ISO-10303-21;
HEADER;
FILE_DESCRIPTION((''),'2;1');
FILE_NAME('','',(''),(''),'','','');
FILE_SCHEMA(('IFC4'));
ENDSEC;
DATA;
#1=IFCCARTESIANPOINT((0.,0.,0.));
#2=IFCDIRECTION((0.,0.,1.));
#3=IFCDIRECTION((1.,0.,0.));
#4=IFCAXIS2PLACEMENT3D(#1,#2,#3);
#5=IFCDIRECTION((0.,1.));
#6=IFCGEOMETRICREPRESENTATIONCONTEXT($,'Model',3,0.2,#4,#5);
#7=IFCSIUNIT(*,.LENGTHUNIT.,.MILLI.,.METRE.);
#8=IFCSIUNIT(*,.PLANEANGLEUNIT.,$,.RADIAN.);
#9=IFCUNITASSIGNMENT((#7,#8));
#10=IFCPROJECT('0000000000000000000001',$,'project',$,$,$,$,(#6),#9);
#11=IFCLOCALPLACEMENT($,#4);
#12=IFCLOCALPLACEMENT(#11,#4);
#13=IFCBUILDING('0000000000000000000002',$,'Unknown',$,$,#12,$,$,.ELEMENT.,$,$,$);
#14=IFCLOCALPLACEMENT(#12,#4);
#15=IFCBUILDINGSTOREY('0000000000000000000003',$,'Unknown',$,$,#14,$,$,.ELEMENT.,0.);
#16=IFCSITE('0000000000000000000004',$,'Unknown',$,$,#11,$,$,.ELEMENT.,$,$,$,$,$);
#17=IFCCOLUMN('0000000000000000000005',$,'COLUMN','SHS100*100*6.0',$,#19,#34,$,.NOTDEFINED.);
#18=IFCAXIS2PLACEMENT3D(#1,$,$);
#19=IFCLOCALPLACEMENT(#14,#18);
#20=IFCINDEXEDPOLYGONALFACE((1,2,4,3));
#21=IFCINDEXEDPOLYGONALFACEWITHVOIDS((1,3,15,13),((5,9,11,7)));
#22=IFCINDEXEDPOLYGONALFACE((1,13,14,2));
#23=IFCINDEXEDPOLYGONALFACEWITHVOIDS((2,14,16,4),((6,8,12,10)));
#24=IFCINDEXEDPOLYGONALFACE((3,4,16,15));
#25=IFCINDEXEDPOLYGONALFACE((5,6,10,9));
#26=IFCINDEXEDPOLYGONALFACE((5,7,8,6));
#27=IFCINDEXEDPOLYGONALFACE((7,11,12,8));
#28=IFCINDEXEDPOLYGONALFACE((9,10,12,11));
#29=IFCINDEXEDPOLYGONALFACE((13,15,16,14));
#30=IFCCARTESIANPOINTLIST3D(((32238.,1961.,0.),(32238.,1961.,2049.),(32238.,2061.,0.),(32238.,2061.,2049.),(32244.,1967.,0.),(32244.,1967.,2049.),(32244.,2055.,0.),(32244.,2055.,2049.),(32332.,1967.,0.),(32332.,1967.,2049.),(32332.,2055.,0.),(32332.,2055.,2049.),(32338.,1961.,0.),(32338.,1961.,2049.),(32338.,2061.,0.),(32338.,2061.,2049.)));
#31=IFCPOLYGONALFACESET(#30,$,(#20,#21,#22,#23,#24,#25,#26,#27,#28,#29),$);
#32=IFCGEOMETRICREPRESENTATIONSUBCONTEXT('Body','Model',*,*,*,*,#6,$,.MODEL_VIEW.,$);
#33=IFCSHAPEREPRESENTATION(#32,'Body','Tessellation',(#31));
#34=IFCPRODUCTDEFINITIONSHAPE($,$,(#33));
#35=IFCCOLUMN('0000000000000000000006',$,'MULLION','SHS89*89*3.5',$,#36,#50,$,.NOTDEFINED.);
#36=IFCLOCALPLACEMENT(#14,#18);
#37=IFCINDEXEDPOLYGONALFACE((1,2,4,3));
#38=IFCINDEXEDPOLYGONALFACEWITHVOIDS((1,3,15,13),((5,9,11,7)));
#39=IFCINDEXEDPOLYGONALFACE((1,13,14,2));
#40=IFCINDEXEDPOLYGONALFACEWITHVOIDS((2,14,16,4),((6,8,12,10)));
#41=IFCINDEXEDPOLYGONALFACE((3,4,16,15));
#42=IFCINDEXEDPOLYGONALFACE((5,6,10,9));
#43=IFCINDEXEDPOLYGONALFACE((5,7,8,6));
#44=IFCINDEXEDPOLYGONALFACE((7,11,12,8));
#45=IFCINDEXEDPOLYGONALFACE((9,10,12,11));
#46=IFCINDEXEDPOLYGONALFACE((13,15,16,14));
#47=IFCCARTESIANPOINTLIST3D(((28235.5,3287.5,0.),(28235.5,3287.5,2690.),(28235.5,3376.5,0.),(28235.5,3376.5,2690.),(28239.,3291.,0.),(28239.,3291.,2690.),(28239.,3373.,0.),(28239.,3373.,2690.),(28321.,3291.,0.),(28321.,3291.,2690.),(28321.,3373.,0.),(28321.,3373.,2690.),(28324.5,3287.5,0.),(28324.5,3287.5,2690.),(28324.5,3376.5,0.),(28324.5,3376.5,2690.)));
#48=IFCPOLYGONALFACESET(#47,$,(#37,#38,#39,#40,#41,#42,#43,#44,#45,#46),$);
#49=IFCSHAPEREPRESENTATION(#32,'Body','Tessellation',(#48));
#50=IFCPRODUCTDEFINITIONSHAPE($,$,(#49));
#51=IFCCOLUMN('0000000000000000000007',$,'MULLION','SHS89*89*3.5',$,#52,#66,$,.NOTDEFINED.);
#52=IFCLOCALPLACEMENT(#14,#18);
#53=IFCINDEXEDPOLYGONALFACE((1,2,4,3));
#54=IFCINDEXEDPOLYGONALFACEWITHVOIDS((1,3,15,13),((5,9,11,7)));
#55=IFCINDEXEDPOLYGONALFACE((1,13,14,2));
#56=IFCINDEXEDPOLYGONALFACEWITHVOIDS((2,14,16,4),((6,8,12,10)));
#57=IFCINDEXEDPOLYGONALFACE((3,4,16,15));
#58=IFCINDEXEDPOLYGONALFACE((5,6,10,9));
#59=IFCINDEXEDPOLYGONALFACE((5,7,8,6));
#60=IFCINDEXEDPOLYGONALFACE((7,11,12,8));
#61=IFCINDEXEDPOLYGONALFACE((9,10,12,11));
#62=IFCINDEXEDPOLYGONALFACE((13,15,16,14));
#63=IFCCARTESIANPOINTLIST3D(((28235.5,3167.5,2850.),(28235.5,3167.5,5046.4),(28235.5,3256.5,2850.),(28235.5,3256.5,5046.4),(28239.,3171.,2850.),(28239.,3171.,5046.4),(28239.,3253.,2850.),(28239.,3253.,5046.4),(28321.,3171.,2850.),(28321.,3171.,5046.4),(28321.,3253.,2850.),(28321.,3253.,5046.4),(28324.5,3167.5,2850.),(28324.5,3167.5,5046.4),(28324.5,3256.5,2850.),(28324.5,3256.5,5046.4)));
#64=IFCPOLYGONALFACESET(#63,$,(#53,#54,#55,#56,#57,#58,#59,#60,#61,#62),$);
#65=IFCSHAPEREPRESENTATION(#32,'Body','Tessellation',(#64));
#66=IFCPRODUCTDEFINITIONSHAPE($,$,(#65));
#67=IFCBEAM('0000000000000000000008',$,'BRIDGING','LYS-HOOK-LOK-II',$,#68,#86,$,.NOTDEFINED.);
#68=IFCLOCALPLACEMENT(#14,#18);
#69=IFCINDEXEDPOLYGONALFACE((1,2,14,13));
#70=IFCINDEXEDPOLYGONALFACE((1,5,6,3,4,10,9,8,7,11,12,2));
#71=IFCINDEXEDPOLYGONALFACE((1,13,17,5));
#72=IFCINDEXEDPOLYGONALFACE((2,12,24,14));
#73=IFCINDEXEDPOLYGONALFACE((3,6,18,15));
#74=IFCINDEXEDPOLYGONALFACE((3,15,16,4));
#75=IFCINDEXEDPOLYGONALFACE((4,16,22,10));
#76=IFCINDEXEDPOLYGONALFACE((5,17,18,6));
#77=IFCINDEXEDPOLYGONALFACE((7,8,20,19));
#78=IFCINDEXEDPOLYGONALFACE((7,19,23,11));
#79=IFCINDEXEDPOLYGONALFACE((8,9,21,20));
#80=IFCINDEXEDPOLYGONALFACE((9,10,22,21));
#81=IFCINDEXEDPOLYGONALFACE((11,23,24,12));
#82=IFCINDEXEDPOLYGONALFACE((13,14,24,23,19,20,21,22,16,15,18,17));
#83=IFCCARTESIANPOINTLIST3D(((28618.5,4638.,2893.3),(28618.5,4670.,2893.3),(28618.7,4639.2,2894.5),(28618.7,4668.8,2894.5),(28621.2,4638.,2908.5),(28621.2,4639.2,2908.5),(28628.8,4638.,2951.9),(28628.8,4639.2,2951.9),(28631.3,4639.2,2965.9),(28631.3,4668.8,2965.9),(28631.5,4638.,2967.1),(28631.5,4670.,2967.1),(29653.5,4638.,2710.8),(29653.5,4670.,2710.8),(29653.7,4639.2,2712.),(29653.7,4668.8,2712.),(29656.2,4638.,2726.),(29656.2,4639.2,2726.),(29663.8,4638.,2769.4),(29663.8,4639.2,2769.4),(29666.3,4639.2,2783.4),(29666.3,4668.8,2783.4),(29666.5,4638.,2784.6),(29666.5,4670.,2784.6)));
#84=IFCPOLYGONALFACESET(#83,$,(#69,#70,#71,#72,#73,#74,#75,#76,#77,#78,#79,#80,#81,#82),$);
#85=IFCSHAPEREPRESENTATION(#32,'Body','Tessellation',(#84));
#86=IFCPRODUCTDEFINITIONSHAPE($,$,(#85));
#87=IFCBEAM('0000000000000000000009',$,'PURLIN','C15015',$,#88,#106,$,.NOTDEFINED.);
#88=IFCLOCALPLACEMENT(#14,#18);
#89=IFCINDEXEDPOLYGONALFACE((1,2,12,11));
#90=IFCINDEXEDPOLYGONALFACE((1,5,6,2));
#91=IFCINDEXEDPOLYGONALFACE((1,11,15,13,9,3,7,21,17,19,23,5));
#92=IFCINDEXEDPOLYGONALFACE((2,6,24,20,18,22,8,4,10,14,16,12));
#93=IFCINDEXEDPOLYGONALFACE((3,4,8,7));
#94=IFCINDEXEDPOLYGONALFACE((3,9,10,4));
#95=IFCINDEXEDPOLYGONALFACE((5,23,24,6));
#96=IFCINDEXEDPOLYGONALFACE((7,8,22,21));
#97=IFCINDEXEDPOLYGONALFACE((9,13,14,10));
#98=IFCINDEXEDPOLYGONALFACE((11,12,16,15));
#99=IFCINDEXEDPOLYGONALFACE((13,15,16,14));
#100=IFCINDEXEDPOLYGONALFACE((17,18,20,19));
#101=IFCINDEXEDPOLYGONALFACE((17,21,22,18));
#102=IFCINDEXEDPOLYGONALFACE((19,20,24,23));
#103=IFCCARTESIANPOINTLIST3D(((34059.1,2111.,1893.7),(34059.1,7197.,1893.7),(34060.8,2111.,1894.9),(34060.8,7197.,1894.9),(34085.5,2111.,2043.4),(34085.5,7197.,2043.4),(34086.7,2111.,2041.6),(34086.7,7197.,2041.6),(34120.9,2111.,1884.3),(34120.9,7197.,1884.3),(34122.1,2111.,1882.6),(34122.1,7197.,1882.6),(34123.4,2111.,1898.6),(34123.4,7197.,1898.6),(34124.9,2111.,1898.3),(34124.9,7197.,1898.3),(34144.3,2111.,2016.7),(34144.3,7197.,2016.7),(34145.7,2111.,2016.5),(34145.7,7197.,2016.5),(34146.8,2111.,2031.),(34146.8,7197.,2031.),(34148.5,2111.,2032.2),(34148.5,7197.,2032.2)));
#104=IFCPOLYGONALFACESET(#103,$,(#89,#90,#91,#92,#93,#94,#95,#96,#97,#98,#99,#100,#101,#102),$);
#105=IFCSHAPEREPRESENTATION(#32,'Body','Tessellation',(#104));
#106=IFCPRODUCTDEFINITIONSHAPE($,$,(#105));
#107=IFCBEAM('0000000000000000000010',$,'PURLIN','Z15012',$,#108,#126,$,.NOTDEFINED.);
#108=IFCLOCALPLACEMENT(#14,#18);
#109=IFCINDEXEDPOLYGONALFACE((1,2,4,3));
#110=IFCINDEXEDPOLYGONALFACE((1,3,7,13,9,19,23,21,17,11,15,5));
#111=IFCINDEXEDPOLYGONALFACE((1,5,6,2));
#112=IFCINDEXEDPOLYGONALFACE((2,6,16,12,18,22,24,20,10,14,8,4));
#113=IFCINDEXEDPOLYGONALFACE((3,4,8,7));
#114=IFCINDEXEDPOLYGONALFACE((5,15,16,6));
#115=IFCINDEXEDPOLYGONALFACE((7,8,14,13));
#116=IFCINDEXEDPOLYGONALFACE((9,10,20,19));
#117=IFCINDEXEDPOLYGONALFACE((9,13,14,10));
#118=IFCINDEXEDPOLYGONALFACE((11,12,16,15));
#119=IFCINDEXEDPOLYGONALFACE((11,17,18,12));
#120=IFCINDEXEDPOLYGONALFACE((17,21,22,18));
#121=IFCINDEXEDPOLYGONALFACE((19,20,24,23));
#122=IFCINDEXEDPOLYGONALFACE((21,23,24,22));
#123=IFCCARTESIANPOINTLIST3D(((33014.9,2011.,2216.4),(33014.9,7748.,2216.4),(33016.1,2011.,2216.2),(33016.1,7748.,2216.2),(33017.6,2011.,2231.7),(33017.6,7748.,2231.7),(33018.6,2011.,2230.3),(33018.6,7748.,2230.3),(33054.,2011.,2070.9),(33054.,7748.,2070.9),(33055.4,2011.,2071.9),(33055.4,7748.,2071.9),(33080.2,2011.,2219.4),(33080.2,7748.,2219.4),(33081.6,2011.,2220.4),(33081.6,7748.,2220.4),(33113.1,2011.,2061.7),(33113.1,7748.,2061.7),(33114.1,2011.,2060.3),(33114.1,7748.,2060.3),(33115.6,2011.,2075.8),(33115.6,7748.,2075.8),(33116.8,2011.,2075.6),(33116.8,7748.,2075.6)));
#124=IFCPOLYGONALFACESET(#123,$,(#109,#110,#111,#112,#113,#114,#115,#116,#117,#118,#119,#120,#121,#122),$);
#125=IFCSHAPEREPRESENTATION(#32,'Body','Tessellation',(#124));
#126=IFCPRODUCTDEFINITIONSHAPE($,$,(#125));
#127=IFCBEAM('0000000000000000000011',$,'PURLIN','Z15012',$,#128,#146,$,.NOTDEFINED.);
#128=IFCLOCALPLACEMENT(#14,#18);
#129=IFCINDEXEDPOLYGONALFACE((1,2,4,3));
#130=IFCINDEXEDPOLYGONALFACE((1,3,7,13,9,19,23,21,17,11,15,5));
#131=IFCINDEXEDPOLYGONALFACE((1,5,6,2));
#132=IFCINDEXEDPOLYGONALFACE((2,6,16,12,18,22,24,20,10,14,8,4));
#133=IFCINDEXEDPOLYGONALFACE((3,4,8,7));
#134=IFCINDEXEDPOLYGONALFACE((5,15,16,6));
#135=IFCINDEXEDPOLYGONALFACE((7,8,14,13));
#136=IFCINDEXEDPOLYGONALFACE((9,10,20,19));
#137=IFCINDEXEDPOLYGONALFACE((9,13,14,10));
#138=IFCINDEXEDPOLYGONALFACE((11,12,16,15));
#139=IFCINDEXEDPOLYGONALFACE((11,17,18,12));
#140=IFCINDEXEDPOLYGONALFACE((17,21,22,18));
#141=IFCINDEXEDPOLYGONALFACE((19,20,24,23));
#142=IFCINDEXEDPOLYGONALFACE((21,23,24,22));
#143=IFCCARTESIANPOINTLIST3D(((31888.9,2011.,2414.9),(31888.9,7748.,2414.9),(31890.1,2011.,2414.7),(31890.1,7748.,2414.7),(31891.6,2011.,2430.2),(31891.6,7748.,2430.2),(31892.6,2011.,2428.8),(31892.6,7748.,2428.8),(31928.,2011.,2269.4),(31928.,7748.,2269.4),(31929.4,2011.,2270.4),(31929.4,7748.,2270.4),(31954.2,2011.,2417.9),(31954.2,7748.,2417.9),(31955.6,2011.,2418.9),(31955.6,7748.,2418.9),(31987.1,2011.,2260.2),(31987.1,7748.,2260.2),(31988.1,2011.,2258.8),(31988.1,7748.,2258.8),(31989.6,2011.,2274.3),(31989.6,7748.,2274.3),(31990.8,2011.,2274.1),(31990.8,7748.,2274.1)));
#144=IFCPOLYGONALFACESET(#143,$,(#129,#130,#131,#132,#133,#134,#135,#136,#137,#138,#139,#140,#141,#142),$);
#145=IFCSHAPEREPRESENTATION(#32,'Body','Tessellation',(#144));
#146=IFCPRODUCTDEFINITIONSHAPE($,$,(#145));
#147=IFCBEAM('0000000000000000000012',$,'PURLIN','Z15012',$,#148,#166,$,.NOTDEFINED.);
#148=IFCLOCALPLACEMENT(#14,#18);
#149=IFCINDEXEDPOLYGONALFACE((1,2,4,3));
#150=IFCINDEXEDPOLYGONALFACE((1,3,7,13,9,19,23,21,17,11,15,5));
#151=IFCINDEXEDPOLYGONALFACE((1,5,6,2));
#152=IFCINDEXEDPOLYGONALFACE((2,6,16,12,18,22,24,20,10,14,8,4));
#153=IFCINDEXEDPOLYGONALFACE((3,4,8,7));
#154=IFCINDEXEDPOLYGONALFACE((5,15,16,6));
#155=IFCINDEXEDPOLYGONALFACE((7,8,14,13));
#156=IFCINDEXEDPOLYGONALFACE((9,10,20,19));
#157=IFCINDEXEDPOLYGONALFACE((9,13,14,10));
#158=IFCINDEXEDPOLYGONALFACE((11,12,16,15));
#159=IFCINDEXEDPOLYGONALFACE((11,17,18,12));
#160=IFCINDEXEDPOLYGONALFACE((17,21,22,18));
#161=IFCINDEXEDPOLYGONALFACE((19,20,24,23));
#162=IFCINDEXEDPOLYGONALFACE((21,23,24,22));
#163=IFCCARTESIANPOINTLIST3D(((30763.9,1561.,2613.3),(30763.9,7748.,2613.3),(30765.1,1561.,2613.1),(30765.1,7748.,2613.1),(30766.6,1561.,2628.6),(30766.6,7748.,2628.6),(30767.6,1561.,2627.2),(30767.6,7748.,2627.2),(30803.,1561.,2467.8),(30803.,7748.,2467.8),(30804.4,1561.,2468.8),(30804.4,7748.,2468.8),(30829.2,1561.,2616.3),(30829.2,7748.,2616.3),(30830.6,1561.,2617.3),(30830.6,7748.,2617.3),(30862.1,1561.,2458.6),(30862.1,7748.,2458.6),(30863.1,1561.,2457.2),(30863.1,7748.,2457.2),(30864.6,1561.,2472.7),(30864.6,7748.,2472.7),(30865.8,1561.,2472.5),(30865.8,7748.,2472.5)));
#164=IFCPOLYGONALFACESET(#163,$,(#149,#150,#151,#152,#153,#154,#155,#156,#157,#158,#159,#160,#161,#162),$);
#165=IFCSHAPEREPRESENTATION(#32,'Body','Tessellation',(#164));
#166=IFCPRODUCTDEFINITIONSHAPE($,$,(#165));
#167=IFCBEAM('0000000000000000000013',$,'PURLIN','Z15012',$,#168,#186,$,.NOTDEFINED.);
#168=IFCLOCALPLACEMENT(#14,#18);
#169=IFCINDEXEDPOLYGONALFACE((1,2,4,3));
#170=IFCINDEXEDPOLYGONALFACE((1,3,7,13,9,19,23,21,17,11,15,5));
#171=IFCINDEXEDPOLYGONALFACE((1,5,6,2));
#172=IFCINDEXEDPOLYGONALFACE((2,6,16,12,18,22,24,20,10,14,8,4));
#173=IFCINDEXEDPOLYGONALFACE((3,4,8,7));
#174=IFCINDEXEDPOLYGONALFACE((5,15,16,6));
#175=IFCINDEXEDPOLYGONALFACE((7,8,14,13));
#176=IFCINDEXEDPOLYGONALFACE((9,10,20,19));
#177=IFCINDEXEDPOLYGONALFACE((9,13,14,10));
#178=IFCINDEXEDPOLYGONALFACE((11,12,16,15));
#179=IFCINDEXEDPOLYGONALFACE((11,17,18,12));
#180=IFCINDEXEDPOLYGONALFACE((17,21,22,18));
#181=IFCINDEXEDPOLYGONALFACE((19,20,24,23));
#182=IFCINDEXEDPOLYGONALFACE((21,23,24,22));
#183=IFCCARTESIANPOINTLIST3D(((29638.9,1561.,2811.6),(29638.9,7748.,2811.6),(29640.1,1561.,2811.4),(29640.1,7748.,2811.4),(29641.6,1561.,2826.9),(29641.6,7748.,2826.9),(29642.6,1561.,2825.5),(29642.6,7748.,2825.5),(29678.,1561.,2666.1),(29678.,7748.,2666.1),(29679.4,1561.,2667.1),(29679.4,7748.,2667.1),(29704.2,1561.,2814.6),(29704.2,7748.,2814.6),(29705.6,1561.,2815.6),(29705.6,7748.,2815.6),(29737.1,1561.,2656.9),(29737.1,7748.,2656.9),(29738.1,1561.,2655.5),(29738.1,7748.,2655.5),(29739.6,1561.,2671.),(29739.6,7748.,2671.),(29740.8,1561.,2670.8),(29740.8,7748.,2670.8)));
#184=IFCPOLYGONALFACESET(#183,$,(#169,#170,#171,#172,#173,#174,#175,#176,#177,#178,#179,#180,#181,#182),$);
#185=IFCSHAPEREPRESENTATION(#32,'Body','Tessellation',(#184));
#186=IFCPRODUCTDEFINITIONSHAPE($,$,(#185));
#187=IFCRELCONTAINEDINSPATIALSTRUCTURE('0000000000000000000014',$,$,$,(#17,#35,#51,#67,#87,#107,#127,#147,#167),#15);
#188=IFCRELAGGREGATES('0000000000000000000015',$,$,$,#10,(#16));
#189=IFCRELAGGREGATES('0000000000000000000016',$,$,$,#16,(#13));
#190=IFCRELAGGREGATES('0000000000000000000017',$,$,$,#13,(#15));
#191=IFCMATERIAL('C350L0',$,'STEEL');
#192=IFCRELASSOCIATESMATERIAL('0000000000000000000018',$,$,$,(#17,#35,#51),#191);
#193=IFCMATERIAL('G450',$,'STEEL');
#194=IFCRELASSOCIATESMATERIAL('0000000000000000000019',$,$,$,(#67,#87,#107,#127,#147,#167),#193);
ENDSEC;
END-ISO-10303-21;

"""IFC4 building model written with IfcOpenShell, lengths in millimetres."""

from ifc_helpers import new_model, si_unit, direction, frame, origin_with_axes, place, context, subcontext, project, spatial, line, indexed_curve, outline, extrude, material, element, save


model = new_model("IFC4")

# Units and contexts
model_context = context("Model", 3, precision=0.2, world=origin_with_axes(), true_north=direction((0.0, 1.0)))
body_context = subcontext(model_context, "Body", "Model", "MODEL_VIEW")
ifc_project = project(units=[si_unit("LENGTHUNIT", "METRE", prefix="MILLI"), si_unit("PLANEANGLEUNIT", "RADIAN")], contexts=[model_context])

# Site, building, storey
site_placement = place(None, origin_with_axes())
site = spatial("IfcSite", under=ifc_project, at=site_placement, Name="Unknown", CompositionType="ELEMENT")
building_placement = place(site_placement, origin_with_axes())
building = spatial("IfcBuilding", under=site, at=building_placement, Name="Unknown", CompositionType="ELEMENT")
storey_placement = place(building_placement, origin_with_axes())
storey = spatial("IfcBuildingStorey", under=building, at=storey_placement, Name="Unknown", CompositionType="ELEMENT", Elevation=0.0)

# Columns
ifc_material_1 = material(Name="C350L0", Category="STEEL")
column_1_placement = place(storey_placement, frame((32288.0, 2011.0, 0.0), z_axis=(-1.0, 0.0, 0.0), x_axis=(0.0, 0.0, 1.0)))
element("IfcColumn", 1, at=column_1_placement, inside=storey, material=ifc_material_1, Name="COLUMN", Description="SHS100*100*6.0", PredefinedType="NOTDEFINED", context=body_context, shape_type="SolidModel", body=[
    extrude(outline(indexed_curve([(-50.0, -50.0), (50.0, -50.0), (50.0, 50.0), (-50.0, 50.0)], segments=[line(1, 2, 3, 4, 1)]), holes=[indexed_curve([(-44.0, -44.0), (-44.0, 44.0), (44.0, 44.0), (44.0, -44.0)], segments=[line(1, 2, 3, 4, 1)])]), frame((0.0, 0.0, 0.0), z_axis=(-1.0, 0.0, 0.0), x_axis=(0.0, 0.0, 1.0)), (0.0, 0.0, -1.0), 2049.0),
])
column_2_placement = place(storey_placement, frame((28280.0, 3332.0, 0.0), z_axis=(-1.0, 0.0, 0.0), x_axis=(0.0, 0.0, 1.0)))
element("IfcColumn", 2, at=column_2_placement, inside=storey, material=ifc_material_1, Name="MULLION", Description="SHS89*89*3.5", PredefinedType="NOTDEFINED", context=body_context, shape_type="SolidModel", body=[
    extrude(outline(indexed_curve([(-44.5, -44.5), (44.5, -44.5), (44.5, 44.5), (-44.5, 44.5)], segments=[line(1, 2, 3, 4, 1)]), holes=[indexed_curve([(-41.0, -41.0), (-41.0, 41.0), (41.0, 41.0), (41.0, -41.0)], segments=[line(1, 2, 3, 4, 1)])]), frame((0.0, 0.0, 0.0), z_axis=(-1.0, 0.0, 0.0), x_axis=(0.0, 0.0, 1.0)), (0.0, 0.0, -1.0), 2690.0),
])
column_3_placement = place(storey_placement, frame((28280.0, 3212.0, 2850.0), z_axis=(-1.0, 0.0, 0.0), x_axis=(0.0, 0.0, 1.0)))
element("IfcColumn", 3, at=column_3_placement, inside=storey, material=ifc_material_1, Name="MULLION", Description="SHS89*89*3.5", PredefinedType="NOTDEFINED", context=body_context, shape_type="SolidModel", body=[
    extrude(outline(indexed_curve([(-44.5, -44.5), (44.5, -44.5), (44.5, 44.5), (-44.5, 44.5)], segments=[line(1, 2, 3, 4, 1)]), holes=[indexed_curve([(-41.0, -41.0), (-41.0, 41.0), (41.0, 41.0), (41.0, -41.0)], segments=[line(1, 2, 3, 4, 1)])]), frame((0.0, 0.0, 0.0), z_axis=(-1.0, 0.0, 0.0), x_axis=(0.0, 0.0, 1.0)), (0.0, 0.0, -1.0), 2196.4),
])

# Beams
ifc_material_2 = material(Name="G450", Category="STEEL")
beam_1_placement = place(storey_placement, frame((28625.0, 4654.0, 2930.2), z_axis=(0.0, -1.0, 0.0), x_axis=(0.984807, 0.0, -0.17365)))
element("IfcBeam", 4, at=beam_1_placement, inside=storey, material=ifc_material_2, Name="BRIDGING", Description="LYS-HOOK-LOK-II", PredefinedType="NOTDEFINED", context=body_context, shape_type="SolidModel", body=[
    extrude(outline(indexed_curve([(16.0, -37.5), (16.0, -22.0), (14.8, -22.0), (14.8, -36.3), (-14.8, -36.3), (-14.8, 36.3), (14.8, 36.3), (14.8, 22.0), (16.0, 22.0), (16.0, 37.5), (-16.0, 37.5), (-16.0, -37.5)], segments=[line(1, 2, 3, 4, 5, 6, 7, 8, 9, 10, 11, 12, 1)])), frame((0.0, 0.0, 0.0), z_axis=(-1.0, 0.0, 0.0), x_axis=(0.0, 0.0, 1.0)), (0.0, 0.0, -1.0), 1051.0),
])
beam_2_placement = place(storey_placement, frame((34103.8, 2111.0, 1963.0), z_axis=(0.984808, 0.0, -0.173648), x_axis=(0.0, 1.0, 0.0)))
element("IfcBeam", 5, at=beam_2_placement, inside=storey, material=ifc_material_2, Name="PURLIN", Description="C15015", PredefinedType="NOTDEFINED", context=body_context, shape_type="SolidModel", body=[
    extrude(outline(indexed_curve([(32.0, -76.0), (32.0, -60.0), (30.5, -60.0), (30.5, -74.5), (-30.5, -74.5), (-30.5, 74.5), (30.5, 74.5), (30.5, 60.0), (32.0, 60.0), (32.0, 76.0), (-32.0, 76.0), (-32.0, -76.0)], segments=[line(1, 2, 3, 4, 5, 6, 7, 8, 9, 10, 11, 12, 1)])), frame((0.0, 0.0, 0.0), z_axis=(-1.0, 0.0, 0.0), x_axis=(0.0, 0.0, 1.0)), (0.0, 0.0, -1.0), 5086.0),
])
for number, where, z_axis, x_axis, name in (
    (6, (33067.8, 2011.0, 2145.7), (0.984808, 0.0, -0.173648), (0.0, 1.0, 0.0), "PURLIN"),
    (7, (31941.8, 2011.0, 2344.2), (0.984808, 0.0, -0.173648), (0.0, 1.0, 0.0), "PURLIN"),
):
    element("IfcBeam", number, at=place(storey_placement, frame(where, z_axis=z_axis, x_axis=x_axis)), inside=storey, material=ifc_material_2, Name=name, Description="Z15012", PredefinedType="NOTDEFINED", context=body_context, shape_type="SolidModel", body=[
        extrude(outline(indexed_curve([(60.4, -76.0), (60.4, -60.5), (59.2, -60.5), (59.2, -74.8), (0.6, -74.8), (0.6, 76.0), (-64.4, 76.0), (-64.4, 60.5), (-63.2, 60.5), (-63.2, 74.8), (-0.6, 74.8), (-0.6, -76.0)], segments=[line(1, 2, 3, 4, 5, 6, 7, 8, 9, 10, 11, 12, 1)])), frame((0.0, 0.0, 0.0), z_axis=(-1.0, 0.0, 0.0), x_axis=(0.0, 0.0, 1.0)), (0.0, 0.0, -1.0), 5737.0),
    ])
for number, where, z_axis, x_axis, name in (
    (8, (30816.8, 1561.0, 2542.6), (0.984808, 0.0, -0.173648), (0.0, 1.0, 0.0), "PURLIN"),
    (9, (29691.8, 1561.0, 2740.9), (0.984808, 0.0, -0.173648), (0.0, 1.0, 0.0), "PURLIN"),
):
    element("IfcBeam", number, at=place(storey_placement, frame(where, z_axis=z_axis, x_axis=x_axis)), inside=storey, material=ifc_material_2, Name=name, Description="Z15012", PredefinedType="NOTDEFINED", context=body_context, shape_type="SolidModel", body=[
        extrude(outline(indexed_curve([(60.4, -76.0), (60.4, -60.5), (59.2, -60.5), (59.2, -74.8), (0.6, -74.8), (0.6, 76.0), (-64.4, 76.0), (-64.4, 60.5), (-63.2, 60.5), (-63.2, 74.8), (-0.6, 74.8), (-0.6, -76.0)], segments=[line(1, 2, 3, 4, 5, 6, 7, 8, 9, 10, 11, 12, 1)])), frame((0.0, 0.0, 0.0), z_axis=(-1.0, 0.0, 0.0), x_axis=(0.0, 0.0, 1.0)), (0.0, 0.0, -1.0), 6187.0),
    ])

save(model, "model.ifc")
